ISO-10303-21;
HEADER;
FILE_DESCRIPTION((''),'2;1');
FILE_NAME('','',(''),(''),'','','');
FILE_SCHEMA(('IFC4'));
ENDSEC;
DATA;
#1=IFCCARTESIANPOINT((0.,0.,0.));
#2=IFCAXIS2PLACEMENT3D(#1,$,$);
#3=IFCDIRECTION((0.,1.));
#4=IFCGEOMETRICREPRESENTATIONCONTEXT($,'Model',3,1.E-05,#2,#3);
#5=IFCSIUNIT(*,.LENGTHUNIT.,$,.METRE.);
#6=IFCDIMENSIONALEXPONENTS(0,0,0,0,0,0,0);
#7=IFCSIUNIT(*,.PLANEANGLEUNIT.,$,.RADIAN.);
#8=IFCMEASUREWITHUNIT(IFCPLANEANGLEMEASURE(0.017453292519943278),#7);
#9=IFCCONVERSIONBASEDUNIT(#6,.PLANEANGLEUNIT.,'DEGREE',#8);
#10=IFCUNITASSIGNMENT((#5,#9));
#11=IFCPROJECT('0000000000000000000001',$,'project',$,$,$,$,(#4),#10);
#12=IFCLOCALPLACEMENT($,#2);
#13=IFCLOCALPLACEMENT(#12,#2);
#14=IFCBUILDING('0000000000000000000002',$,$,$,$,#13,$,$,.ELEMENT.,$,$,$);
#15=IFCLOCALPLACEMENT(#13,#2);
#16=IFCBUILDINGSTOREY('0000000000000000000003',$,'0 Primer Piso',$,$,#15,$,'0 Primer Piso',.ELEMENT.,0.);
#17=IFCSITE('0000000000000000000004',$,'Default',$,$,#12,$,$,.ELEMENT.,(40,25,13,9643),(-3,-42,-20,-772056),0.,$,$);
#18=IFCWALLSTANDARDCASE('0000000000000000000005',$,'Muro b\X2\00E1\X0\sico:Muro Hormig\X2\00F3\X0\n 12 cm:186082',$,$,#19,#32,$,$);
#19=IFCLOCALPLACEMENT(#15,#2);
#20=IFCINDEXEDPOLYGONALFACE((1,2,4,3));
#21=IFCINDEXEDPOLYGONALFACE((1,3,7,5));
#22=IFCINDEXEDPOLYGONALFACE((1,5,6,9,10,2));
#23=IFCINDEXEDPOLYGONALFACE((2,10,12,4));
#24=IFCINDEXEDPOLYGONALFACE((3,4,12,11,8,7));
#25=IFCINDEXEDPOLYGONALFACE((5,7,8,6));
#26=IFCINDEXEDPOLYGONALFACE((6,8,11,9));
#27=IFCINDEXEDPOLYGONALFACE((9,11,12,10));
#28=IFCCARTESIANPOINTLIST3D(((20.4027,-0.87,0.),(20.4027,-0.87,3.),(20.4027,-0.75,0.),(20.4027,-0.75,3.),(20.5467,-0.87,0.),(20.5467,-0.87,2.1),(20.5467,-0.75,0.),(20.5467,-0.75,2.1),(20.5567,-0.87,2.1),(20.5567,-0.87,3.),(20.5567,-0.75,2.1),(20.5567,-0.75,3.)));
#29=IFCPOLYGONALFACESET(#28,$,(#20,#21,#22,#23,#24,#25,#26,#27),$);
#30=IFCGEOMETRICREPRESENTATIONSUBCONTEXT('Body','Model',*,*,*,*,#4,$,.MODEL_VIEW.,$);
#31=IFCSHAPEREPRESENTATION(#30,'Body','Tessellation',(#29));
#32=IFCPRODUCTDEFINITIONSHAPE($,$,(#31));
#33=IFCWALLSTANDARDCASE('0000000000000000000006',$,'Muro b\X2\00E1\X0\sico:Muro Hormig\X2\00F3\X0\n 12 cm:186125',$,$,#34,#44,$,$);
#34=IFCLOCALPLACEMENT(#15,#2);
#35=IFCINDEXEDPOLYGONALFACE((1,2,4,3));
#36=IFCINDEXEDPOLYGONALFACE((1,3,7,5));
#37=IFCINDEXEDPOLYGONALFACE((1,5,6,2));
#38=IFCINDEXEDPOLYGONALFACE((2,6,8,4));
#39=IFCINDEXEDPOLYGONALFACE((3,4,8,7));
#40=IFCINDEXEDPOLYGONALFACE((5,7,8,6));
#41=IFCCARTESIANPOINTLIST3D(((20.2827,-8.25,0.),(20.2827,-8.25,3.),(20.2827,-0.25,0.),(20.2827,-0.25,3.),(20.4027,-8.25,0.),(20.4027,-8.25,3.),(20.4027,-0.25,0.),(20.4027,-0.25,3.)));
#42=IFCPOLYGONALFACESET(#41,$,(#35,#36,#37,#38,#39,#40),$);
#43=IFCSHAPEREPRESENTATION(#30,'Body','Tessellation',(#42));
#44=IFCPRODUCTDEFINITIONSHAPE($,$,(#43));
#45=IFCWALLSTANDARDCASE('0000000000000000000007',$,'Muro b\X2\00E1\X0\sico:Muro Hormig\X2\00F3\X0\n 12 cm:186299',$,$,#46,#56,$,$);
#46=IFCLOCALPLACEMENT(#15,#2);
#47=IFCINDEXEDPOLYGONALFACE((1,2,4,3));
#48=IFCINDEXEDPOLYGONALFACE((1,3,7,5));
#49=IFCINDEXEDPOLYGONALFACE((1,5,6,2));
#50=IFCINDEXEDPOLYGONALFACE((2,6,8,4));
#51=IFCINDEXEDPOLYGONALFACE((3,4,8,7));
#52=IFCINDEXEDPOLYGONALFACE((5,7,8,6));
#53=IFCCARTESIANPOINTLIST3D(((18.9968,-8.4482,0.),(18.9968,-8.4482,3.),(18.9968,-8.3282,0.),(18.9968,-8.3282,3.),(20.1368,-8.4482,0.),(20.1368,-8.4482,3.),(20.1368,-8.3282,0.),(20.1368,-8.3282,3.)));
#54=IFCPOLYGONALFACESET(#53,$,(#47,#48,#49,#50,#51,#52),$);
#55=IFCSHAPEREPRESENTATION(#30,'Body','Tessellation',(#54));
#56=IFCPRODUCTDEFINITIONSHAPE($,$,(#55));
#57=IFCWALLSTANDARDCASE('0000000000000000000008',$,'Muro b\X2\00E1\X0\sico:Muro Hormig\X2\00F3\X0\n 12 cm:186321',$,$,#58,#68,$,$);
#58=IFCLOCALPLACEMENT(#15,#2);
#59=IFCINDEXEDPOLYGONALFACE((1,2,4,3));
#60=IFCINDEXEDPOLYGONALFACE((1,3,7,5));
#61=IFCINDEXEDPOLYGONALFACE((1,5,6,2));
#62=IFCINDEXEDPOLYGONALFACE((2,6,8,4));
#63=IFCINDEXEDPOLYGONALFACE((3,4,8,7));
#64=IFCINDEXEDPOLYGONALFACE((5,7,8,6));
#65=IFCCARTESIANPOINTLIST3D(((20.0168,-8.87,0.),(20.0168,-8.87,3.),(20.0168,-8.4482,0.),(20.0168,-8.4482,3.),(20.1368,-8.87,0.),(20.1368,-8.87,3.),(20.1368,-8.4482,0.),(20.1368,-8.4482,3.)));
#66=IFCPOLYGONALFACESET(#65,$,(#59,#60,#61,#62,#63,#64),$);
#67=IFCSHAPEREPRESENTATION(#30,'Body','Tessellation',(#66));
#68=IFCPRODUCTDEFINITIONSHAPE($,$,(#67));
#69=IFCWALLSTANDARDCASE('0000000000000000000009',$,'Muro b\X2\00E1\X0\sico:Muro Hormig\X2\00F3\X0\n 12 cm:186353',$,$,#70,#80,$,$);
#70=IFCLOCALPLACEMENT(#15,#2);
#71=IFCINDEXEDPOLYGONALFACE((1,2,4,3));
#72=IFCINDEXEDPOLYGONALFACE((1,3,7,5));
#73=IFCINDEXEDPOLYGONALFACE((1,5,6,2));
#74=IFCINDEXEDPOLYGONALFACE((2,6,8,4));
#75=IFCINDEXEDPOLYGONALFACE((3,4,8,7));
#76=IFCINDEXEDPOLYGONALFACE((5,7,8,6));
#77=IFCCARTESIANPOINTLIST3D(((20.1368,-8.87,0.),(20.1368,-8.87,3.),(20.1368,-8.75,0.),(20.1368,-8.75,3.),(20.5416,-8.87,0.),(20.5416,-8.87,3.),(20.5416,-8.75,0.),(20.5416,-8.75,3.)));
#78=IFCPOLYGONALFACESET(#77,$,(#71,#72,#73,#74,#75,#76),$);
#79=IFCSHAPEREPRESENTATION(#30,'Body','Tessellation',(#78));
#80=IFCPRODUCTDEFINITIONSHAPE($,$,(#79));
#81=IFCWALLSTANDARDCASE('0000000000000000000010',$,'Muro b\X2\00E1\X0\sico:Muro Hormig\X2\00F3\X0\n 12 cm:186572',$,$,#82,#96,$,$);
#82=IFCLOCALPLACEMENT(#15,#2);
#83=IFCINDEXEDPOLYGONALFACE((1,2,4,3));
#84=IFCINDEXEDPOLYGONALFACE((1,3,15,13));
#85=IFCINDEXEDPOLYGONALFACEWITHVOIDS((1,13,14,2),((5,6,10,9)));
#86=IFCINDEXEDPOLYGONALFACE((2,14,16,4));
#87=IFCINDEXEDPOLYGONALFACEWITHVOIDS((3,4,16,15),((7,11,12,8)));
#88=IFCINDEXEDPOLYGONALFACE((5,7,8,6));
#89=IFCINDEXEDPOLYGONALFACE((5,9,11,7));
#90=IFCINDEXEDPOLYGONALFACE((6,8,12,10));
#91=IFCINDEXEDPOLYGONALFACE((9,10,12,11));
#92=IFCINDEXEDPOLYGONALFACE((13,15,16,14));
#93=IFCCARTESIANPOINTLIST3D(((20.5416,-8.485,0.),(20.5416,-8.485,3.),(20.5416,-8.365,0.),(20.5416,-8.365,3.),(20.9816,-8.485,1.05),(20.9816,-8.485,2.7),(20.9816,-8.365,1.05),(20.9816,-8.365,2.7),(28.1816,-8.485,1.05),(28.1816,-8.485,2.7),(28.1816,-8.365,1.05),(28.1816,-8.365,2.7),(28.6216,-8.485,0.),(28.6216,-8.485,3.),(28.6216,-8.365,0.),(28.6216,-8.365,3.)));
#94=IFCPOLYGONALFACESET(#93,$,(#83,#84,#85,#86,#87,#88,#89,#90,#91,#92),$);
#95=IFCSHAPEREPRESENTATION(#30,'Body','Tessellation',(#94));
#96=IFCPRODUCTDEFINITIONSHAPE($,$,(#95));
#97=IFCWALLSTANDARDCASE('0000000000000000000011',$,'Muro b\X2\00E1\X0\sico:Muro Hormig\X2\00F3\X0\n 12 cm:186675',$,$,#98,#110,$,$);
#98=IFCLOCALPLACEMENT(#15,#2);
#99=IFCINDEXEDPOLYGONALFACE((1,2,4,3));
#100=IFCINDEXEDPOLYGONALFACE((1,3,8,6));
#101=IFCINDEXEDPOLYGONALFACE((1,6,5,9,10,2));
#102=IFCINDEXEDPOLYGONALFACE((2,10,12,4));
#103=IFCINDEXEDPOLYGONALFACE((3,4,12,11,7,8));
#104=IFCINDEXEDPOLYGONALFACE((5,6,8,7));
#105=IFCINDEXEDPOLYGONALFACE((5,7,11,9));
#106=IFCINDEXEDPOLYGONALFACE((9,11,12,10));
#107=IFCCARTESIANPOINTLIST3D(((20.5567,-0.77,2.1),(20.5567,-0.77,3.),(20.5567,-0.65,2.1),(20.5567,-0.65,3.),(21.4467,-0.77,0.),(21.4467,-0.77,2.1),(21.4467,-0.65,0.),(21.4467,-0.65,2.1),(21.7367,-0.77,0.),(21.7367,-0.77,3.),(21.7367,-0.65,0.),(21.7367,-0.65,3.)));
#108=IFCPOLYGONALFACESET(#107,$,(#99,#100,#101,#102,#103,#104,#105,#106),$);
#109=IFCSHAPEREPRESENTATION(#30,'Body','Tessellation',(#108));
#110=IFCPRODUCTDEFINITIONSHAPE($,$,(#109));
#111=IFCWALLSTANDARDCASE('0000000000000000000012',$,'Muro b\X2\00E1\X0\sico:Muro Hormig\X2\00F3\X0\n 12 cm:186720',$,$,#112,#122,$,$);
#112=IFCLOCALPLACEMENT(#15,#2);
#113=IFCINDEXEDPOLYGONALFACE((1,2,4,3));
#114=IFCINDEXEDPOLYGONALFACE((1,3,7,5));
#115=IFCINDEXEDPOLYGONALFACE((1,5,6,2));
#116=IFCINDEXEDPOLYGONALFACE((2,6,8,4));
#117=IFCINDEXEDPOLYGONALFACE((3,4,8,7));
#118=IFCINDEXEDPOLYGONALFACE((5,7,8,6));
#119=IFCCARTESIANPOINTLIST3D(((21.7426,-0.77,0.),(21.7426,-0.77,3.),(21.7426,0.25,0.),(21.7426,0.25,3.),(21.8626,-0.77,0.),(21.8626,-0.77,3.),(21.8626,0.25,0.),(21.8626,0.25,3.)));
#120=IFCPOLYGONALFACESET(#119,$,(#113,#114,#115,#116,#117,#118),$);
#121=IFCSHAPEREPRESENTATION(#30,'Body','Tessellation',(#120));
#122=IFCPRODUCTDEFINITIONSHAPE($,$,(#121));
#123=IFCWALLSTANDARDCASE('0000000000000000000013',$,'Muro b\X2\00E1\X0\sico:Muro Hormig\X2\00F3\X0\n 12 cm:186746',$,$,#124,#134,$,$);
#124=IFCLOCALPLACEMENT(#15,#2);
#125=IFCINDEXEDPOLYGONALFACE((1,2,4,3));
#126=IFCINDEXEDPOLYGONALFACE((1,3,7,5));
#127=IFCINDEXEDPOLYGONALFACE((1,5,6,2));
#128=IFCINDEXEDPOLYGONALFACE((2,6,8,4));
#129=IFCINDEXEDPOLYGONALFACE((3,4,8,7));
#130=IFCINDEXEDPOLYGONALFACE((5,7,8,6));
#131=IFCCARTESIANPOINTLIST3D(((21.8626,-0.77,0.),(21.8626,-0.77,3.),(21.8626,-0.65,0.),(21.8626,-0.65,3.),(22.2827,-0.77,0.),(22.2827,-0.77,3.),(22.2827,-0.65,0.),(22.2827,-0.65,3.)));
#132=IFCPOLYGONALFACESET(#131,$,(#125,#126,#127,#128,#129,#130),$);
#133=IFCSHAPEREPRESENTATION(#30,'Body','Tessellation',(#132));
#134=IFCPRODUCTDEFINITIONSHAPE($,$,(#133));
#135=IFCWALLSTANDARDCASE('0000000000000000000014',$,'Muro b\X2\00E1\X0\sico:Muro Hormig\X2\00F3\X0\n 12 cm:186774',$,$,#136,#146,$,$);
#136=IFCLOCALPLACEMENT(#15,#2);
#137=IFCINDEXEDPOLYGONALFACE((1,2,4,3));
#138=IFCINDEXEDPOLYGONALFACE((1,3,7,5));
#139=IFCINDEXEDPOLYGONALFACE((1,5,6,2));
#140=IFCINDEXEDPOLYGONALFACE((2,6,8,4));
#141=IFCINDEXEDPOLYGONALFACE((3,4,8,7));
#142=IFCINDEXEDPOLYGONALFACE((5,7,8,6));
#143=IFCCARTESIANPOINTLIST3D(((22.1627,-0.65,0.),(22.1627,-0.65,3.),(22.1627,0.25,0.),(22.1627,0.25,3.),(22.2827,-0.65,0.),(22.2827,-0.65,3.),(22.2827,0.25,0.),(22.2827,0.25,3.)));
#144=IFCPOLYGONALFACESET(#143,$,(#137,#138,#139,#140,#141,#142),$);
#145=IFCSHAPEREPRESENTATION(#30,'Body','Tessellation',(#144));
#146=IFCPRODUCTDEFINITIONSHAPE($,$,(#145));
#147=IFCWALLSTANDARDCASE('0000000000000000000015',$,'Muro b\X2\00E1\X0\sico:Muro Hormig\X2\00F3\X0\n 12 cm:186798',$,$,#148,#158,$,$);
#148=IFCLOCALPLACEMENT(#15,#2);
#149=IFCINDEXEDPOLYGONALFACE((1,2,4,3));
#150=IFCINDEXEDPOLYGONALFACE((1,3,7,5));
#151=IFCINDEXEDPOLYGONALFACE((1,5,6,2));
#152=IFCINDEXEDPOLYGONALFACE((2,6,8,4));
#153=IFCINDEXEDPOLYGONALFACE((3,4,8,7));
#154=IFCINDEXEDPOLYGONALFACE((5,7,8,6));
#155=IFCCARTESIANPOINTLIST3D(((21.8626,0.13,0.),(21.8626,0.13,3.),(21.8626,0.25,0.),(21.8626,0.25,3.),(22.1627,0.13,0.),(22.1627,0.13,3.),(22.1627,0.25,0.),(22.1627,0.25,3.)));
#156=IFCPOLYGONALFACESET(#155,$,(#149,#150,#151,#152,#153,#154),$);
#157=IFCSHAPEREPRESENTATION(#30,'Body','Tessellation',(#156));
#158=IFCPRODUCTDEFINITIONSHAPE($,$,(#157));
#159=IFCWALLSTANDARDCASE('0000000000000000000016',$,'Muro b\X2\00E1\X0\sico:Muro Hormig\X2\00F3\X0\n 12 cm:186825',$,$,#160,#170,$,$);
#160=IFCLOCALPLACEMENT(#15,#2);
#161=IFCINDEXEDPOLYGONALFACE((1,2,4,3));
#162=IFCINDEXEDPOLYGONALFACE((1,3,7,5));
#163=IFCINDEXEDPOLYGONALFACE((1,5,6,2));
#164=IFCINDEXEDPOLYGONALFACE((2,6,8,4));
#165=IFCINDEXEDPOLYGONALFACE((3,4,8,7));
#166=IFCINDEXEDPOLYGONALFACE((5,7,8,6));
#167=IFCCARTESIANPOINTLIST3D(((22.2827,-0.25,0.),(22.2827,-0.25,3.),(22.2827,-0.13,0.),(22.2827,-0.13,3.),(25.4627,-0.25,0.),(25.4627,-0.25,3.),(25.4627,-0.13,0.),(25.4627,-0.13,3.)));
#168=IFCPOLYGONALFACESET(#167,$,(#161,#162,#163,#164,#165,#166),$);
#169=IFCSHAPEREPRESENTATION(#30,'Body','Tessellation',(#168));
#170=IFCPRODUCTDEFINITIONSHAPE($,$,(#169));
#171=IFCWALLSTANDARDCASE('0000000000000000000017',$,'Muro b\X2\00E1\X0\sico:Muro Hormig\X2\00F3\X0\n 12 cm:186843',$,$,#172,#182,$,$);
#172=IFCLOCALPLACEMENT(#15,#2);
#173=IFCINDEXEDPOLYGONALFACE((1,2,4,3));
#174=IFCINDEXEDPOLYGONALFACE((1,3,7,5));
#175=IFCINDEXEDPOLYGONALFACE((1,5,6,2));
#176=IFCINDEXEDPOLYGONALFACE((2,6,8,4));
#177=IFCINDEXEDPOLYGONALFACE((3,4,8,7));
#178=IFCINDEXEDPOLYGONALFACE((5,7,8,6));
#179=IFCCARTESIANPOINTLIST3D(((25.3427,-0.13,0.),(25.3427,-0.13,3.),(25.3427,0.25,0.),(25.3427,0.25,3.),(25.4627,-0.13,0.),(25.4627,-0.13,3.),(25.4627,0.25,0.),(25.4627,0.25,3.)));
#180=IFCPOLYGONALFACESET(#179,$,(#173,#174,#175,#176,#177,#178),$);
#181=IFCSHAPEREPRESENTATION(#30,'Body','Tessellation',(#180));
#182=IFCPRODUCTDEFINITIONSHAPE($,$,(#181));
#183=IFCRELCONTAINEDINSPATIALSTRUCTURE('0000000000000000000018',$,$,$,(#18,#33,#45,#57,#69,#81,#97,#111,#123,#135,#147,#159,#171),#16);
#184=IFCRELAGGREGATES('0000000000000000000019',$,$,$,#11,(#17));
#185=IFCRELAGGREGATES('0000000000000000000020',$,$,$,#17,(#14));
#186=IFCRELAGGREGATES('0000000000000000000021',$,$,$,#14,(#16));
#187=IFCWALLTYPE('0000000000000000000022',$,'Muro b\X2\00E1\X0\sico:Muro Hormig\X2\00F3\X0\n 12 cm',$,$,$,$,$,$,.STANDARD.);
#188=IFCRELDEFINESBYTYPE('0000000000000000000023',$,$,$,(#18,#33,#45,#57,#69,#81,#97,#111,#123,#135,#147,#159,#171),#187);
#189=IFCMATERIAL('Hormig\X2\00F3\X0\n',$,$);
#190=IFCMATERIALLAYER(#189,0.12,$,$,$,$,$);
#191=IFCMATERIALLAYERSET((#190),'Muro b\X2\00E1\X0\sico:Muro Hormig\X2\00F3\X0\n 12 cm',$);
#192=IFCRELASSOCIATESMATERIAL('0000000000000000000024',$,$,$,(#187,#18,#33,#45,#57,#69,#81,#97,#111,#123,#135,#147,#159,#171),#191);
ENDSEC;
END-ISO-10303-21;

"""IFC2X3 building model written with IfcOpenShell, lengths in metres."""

from ifc_helpers import new_model, entity, si_unit, converted_unit, direction, frame, frame_2d, origin, place, context, subcontext, project, spatial, rectangle, extrude, material, layer, layer_set, layer_usage, type_object, element, save


model = new_model("IFC2X3")

# Units and contexts
model_context = context("Model", 3, precision=1e-05, world=origin(), true_north=direction((0.0, 1.0)))
body_context = subcontext(model_context, "Body", "Model", "MODEL_VIEW")
ifc_project = project(units=[si_unit("LENGTHUNIT", "METRE"), converted_unit("PLANEANGLEUNIT", "DEGREE", entity("IfcPlaneAngleMeasure", 0.017453292519943278), si_unit("PLANEANGLEUNIT", "RADIAN"), dimensions=[0, 0, 0, 0, 0, 0, 0])], contexts=[model_context])

# Site, building, storey
site_placement = place(None, origin())
site = spatial("IfcSite", under=ifc_project, at=site_placement, Name="Default", CompositionType="ELEMENT", RefLatitude=(40, 25, 13, 9643), RefLongitude=(-3, -42, -20, -772056), RefElevation=0.0)
building_placement = place(site_placement, origin())
building = spatial("IfcBuilding", under=site, at=building_placement, CompositionType="ELEMENT")
storey_placement = place(building_placement, origin())
storey = spatial("IfcBuildingStorey", under=building, at=storey_placement, Name="0 Primer Piso", LongName="0 Primer Piso", CompositionType="ELEMENT", Elevation=0.0)

# Shared definitions
ifc_material = material(Name="Hormigón")
ifc_layer = layer(ifc_material, 0.12)
ifc_layer_set = layer_set([ifc_layer], Name="Muro básico:Muro Hormigón 12 cm")
wall_type = type_object("IfcWallType", Name="Muro básico:Muro Hormigón 12 cm", PredefinedType="STANDARD", material=ifc_layer_set)

# Wall, opening
ifc_layer_usage_1 = layer_usage(ifc_layer_set, "AXIS2", "NEGATIVE", 0.06)
wall_1_placement = place(storey_placement, frame((20.5567, -0.81, 0.0), z_axis=(0.0, 0.0, 1.0), x_axis=(-1.0, 0.0, 0.0)))
wall_1 = element("IfcWallStandardCase", 1, at=wall_1_placement, inside=storey, type_object=wall_type, material=ifc_layer_usage_1, Name="Muro básico:Muro Hormigón 12 cm:186082", context=body_context, shape_type="SweptSolid", body=[
    extrude(rectangle(XDim=0.154, YDim=0.12, at=frame_2d((0.077, 0.0), x_axis=(-1.0, 0.0))), origin(), (0.0, 0.0, 1.0), 3.0),
])
opening_1_placement = place(wall_1_placement, origin())
element("IfcOpeningElement", 2, at=opening_1_placement, cuts=wall_1, ObjectType="Opening", context=body_context, shape_type="SweptSolid", body=[
    extrude(rectangle(XDim=2.1, YDim=0.9, at=frame_2d((0.0, 0.0), x_axis=(0.0, 1.0))), frame((-0.44, -1.564, 1.05), z_axis=(0.0, 1.0, 0.0), x_axis=(-1.0, 0.0, 0.0)), (0.0, 0.0, 1.0), 3.048),
])

# Walls
ifc_layer_usage_2 = layer_usage(ifc_layer_set, "AXIS2", "NEGATIVE", 0.06)
wall_2_placement = place(storey_placement, frame((20.3427, -8.25, 0.0), z_axis=(0.0, 0.0, 1.0), x_axis=(0.0, 1.0, 0.0)))
element("IfcWallStandardCase", 3, at=wall_2_placement, inside=storey, type_object=wall_type, material=ifc_layer_usage_2, Name="Muro básico:Muro Hormigón 12 cm:186125", context=body_context, shape_type="SweptSolid", body=[
    extrude(rectangle(XDim=8.0, YDim=0.12, at=frame_2d((4.0, 0.0), x_axis=(-1.0, 0.0))), origin(), (0.0, 0.0, 1.0), 3.0),
])
ifc_layer_usage_3 = layer_usage(ifc_layer_set, "AXIS2", "NEGATIVE", 0.06)
wall_3_placement = place(storey_placement, frame((18.9968, -8.3882, 0.0)))
element("IfcWallStandardCase", 4, at=wall_3_placement, inside=storey, type_object=wall_type, material=ifc_layer_usage_3, Name="Muro básico:Muro Hormigón 12 cm:186299", context=body_context, shape_type="SweptSolid", body=[
    extrude(rectangle(XDim=1.14, YDim=0.12, at=frame_2d((0.57, 0.0), x_axis=(-1.0, 0.0))), origin(), (0.0, 0.0, 1.0), 3.0),
])
ifc_layer_usage_4 = layer_usage(ifc_layer_set, "AXIS2", "NEGATIVE", 0.06)
wall_4_placement = place(storey_placement, frame((20.0768, -8.4482, 0.0), z_axis=(0.0, 0.0, 1.0), x_axis=(0.0, -1.0, 0.0)))
element("IfcWallStandardCase", 5, at=wall_4_placement, inside=storey, type_object=wall_type, material=ifc_layer_usage_4, Name="Muro básico:Muro Hormigón 12 cm:186321", context=body_context, shape_type="SweptSolid", body=[
    extrude(rectangle(XDim=0.4219, YDim=0.12, at=frame_2d((0.2109, 0.0), x_axis=(-1.0, 0.0))), origin(), (0.0, 0.0, 1.0), 3.0),
])
ifc_layer_usage_5 = layer_usage(ifc_layer_set, "AXIS2", "NEGATIVE", 0.06)
wall_5_placement = place(storey_placement, frame((20.1368, -8.81, 0.0)))
element("IfcWallStandardCase", 6, at=wall_5_placement, inside=storey, type_object=wall_type, material=ifc_layer_usage_5, Name="Muro básico:Muro Hormigón 12 cm:186353", context=body_context, shape_type="SweptSolid", body=[
    extrude(rectangle(XDim=0.4049, YDim=0.12, at=frame_2d((0.2024, 0.0), x_axis=(-1.0, 0.0))), origin(), (0.0, 0.0, 1.0), 3.0),
])

# Walls, openings
ifc_layer_usage_6 = layer_usage(ifc_layer_set, "AXIS2", "NEGATIVE", 0.06)
wall_6_placement = place(storey_placement, frame((20.5416, -8.425, 0.0)))
wall_6 = element("IfcWallStandardCase", 7, at=wall_6_placement, inside=storey, type_object=wall_type, material=ifc_layer_usage_6, Name="Muro básico:Muro Hormigón 12 cm:186572", context=body_context, shape_type="SweptSolid", body=[
    extrude(rectangle(XDim=8.08, YDim=0.12, at=frame_2d((4.04, 0.0), x_axis=(-1.0, 0.0))), origin(), (0.0, 0.0, 1.0), 3.0),
])
opening_2_placement = place(wall_6_placement, frame((7.64, 0.06, 1.05)))
element("IfcOpeningElement", 8, at=opening_2_placement, cuts=wall_6, ObjectType="Opening", context=body_context, shape_type="SweptSolid", body=[
    extrude(rectangle(XDim=1.65, YDim=7.2, at=frame_2d((0.825, 3.6), x_axis=(1.0, 0.0))), frame((0.0, 0.0, 0.0), z_axis=(0.0, -1.0, 0.0), x_axis=(0.0, 0.0, 1.0)), (0.0, 0.0, 1.0), 0.12),
])
ifc_layer_usage_7 = layer_usage(ifc_layer_set, "AXIS2", "NEGATIVE", 0.06)
wall_7_placement = place(storey_placement, frame((20.5567, -0.71, 0.0)))
wall_7 = element("IfcWallStandardCase", 9, at=wall_7_placement, inside=storey, type_object=wall_type, material=ifc_layer_usage_7, Name="Muro básico:Muro Hormigón 12 cm:186675", context=body_context, shape_type="SweptSolid", body=[
    extrude(rectangle(XDim=1.18, YDim=0.12, at=frame_2d((0.59, 0.0), x_axis=(-1.0, 0.0))), origin(), (0.0, 0.0, 1.0), 3.0),
])
opening_3_placement = place(wall_7_placement, frame((-0.01, -0.06, 0.0)))
element("IfcOpeningElement", 10, at=opening_3_placement, cuts=wall_7, ObjectType="Opening", context=body_context, shape_type="SweptSolid", body=[
    extrude(rectangle(XDim=2.1, YDim=0.9, at=frame_2d((1.05, 0.45), x_axis=(1.0, 0.0))), frame((0.0, 0.0, 0.0), z_axis=(0.0, 1.0, 0.0), x_axis=(0.0, 0.0, 1.0)), (0.0, 0.0, 1.0), 0.12),
])

# Walls
ifc_layer_usage_8 = layer_usage(ifc_layer_set, "AXIS2", "NEGATIVE", 0.06)
wall_8_placement = place(storey_placement, frame((21.8026, 0.25, 0.0), z_axis=(0.0, 0.0, 1.0), x_axis=(0.0, -1.0, 0.0)))
element("IfcWallStandardCase", 11, at=wall_8_placement, inside=storey, type_object=wall_type, material=ifc_layer_usage_8, Name="Muro básico:Muro Hormigón 12 cm:186720", context=body_context, shape_type="SweptSolid", body=[
    extrude(rectangle(XDim=1.02, YDim=0.12, at=frame_2d((0.51, 0.0), x_axis=(-1.0, 0.0))), origin(), (0.0, 0.0, 1.0), 3.0),
])
ifc_layer_usage_9 = layer_usage(ifc_layer_set, "AXIS2", "NEGATIVE", 0.06)
wall_9_placement = place(storey_placement, frame((21.8626, -0.71, 0.0)))
element("IfcWallStandardCase", 12, at=wall_9_placement, inside=storey, type_object=wall_type, material=ifc_layer_usage_9, Name="Muro básico:Muro Hormigón 12 cm:186746", context=body_context, shape_type="SweptSolid", body=[
    extrude(rectangle(XDim=0.4201, YDim=0.12, at=frame_2d((0.21, 0.0), x_axis=(-1.0, 0.0))), origin(), (0.0, 0.0, 1.0), 3.0),
])
ifc_layer_usage_10 = layer_usage(ifc_layer_set, "AXIS2", "NEGATIVE", 0.06)
wall_10_placement = place(storey_placement, frame((22.2227, -0.65, 0.0), z_axis=(0.0, 0.0, 1.0), x_axis=(0.0, 1.0, 0.0)))
element("IfcWallStandardCase", 13, at=wall_10_placement, inside=storey, type_object=wall_type, material=ifc_layer_usage_10, Name="Muro básico:Muro Hormigón 12 cm:186774", context=body_context, shape_type="SweptSolid", body=[
    extrude(rectangle(XDim=0.9, YDim=0.12, at=frame_2d((0.45, 0.0), x_axis=(-1.0, 0.0))), origin(), (0.0, 0.0, 1.0), 3.0),
])
ifc_layer_usage_11 = layer_usage(ifc_layer_set, "AXIS2", "NEGATIVE", 0.06)
wall_11_placement = place(storey_placement, frame((22.1627, 0.19, 0.0), z_axis=(0.0, 0.0, 1.0), x_axis=(-1.0, 0.0, 0.0)))
element("IfcWallStandardCase", 14, at=wall_11_placement, inside=storey, type_object=wall_type, material=ifc_layer_usage_11, Name="Muro básico:Muro Hormigón 12 cm:186798", context=body_context, shape_type="SweptSolid", body=[
    extrude(rectangle(XDim=0.3001, YDim=0.12, at=frame_2d((0.15, 0.0), x_axis=(-1.0, 0.0))), origin(), (0.0, 0.0, 1.0), 3.0),
])
ifc_layer_usage_12 = layer_usage(ifc_layer_set, "AXIS2", "NEGATIVE", 0.06)
wall_12_placement = place(storey_placement, frame((22.2827, -0.19, 0.0)))
element("IfcWallStandardCase", 15, at=wall_12_placement, inside=storey, type_object=wall_type, material=ifc_layer_usage_12, Name="Muro básico:Muro Hormigón 12 cm:186825", context=body_context, shape_type="SweptSolid", body=[
    extrude(rectangle(XDim=3.18, YDim=0.12, at=frame_2d((1.59, 0.0), x_axis=(-1.0, 0.0))), origin(), (0.0, 0.0, 1.0), 3.0),
])
ifc_layer_usage_13 = layer_usage(ifc_layer_set, "AXIS2", "NEGATIVE", 0.06)
wall_13_placement = place(storey_placement, frame((25.4027, -0.13, 0.0), z_axis=(0.0, 0.0, 1.0), x_axis=(0.0, 1.0, 0.0)))
element("IfcWallStandardCase", 16, at=wall_13_placement, inside=storey, type_object=wall_type, material=ifc_layer_usage_13, Name="Muro básico:Muro Hormigón 12 cm:186843", context=body_context, shape_type="SweptSolid", body=[
    extrude(rectangle(XDim=0.38, YDim=0.12, at=frame_2d((0.19, 0.0), x_axis=(-1.0, 0.0))), origin(), (0.0, 0.0, 1.0), 3.0),
])

save(model, "model.ifc")
